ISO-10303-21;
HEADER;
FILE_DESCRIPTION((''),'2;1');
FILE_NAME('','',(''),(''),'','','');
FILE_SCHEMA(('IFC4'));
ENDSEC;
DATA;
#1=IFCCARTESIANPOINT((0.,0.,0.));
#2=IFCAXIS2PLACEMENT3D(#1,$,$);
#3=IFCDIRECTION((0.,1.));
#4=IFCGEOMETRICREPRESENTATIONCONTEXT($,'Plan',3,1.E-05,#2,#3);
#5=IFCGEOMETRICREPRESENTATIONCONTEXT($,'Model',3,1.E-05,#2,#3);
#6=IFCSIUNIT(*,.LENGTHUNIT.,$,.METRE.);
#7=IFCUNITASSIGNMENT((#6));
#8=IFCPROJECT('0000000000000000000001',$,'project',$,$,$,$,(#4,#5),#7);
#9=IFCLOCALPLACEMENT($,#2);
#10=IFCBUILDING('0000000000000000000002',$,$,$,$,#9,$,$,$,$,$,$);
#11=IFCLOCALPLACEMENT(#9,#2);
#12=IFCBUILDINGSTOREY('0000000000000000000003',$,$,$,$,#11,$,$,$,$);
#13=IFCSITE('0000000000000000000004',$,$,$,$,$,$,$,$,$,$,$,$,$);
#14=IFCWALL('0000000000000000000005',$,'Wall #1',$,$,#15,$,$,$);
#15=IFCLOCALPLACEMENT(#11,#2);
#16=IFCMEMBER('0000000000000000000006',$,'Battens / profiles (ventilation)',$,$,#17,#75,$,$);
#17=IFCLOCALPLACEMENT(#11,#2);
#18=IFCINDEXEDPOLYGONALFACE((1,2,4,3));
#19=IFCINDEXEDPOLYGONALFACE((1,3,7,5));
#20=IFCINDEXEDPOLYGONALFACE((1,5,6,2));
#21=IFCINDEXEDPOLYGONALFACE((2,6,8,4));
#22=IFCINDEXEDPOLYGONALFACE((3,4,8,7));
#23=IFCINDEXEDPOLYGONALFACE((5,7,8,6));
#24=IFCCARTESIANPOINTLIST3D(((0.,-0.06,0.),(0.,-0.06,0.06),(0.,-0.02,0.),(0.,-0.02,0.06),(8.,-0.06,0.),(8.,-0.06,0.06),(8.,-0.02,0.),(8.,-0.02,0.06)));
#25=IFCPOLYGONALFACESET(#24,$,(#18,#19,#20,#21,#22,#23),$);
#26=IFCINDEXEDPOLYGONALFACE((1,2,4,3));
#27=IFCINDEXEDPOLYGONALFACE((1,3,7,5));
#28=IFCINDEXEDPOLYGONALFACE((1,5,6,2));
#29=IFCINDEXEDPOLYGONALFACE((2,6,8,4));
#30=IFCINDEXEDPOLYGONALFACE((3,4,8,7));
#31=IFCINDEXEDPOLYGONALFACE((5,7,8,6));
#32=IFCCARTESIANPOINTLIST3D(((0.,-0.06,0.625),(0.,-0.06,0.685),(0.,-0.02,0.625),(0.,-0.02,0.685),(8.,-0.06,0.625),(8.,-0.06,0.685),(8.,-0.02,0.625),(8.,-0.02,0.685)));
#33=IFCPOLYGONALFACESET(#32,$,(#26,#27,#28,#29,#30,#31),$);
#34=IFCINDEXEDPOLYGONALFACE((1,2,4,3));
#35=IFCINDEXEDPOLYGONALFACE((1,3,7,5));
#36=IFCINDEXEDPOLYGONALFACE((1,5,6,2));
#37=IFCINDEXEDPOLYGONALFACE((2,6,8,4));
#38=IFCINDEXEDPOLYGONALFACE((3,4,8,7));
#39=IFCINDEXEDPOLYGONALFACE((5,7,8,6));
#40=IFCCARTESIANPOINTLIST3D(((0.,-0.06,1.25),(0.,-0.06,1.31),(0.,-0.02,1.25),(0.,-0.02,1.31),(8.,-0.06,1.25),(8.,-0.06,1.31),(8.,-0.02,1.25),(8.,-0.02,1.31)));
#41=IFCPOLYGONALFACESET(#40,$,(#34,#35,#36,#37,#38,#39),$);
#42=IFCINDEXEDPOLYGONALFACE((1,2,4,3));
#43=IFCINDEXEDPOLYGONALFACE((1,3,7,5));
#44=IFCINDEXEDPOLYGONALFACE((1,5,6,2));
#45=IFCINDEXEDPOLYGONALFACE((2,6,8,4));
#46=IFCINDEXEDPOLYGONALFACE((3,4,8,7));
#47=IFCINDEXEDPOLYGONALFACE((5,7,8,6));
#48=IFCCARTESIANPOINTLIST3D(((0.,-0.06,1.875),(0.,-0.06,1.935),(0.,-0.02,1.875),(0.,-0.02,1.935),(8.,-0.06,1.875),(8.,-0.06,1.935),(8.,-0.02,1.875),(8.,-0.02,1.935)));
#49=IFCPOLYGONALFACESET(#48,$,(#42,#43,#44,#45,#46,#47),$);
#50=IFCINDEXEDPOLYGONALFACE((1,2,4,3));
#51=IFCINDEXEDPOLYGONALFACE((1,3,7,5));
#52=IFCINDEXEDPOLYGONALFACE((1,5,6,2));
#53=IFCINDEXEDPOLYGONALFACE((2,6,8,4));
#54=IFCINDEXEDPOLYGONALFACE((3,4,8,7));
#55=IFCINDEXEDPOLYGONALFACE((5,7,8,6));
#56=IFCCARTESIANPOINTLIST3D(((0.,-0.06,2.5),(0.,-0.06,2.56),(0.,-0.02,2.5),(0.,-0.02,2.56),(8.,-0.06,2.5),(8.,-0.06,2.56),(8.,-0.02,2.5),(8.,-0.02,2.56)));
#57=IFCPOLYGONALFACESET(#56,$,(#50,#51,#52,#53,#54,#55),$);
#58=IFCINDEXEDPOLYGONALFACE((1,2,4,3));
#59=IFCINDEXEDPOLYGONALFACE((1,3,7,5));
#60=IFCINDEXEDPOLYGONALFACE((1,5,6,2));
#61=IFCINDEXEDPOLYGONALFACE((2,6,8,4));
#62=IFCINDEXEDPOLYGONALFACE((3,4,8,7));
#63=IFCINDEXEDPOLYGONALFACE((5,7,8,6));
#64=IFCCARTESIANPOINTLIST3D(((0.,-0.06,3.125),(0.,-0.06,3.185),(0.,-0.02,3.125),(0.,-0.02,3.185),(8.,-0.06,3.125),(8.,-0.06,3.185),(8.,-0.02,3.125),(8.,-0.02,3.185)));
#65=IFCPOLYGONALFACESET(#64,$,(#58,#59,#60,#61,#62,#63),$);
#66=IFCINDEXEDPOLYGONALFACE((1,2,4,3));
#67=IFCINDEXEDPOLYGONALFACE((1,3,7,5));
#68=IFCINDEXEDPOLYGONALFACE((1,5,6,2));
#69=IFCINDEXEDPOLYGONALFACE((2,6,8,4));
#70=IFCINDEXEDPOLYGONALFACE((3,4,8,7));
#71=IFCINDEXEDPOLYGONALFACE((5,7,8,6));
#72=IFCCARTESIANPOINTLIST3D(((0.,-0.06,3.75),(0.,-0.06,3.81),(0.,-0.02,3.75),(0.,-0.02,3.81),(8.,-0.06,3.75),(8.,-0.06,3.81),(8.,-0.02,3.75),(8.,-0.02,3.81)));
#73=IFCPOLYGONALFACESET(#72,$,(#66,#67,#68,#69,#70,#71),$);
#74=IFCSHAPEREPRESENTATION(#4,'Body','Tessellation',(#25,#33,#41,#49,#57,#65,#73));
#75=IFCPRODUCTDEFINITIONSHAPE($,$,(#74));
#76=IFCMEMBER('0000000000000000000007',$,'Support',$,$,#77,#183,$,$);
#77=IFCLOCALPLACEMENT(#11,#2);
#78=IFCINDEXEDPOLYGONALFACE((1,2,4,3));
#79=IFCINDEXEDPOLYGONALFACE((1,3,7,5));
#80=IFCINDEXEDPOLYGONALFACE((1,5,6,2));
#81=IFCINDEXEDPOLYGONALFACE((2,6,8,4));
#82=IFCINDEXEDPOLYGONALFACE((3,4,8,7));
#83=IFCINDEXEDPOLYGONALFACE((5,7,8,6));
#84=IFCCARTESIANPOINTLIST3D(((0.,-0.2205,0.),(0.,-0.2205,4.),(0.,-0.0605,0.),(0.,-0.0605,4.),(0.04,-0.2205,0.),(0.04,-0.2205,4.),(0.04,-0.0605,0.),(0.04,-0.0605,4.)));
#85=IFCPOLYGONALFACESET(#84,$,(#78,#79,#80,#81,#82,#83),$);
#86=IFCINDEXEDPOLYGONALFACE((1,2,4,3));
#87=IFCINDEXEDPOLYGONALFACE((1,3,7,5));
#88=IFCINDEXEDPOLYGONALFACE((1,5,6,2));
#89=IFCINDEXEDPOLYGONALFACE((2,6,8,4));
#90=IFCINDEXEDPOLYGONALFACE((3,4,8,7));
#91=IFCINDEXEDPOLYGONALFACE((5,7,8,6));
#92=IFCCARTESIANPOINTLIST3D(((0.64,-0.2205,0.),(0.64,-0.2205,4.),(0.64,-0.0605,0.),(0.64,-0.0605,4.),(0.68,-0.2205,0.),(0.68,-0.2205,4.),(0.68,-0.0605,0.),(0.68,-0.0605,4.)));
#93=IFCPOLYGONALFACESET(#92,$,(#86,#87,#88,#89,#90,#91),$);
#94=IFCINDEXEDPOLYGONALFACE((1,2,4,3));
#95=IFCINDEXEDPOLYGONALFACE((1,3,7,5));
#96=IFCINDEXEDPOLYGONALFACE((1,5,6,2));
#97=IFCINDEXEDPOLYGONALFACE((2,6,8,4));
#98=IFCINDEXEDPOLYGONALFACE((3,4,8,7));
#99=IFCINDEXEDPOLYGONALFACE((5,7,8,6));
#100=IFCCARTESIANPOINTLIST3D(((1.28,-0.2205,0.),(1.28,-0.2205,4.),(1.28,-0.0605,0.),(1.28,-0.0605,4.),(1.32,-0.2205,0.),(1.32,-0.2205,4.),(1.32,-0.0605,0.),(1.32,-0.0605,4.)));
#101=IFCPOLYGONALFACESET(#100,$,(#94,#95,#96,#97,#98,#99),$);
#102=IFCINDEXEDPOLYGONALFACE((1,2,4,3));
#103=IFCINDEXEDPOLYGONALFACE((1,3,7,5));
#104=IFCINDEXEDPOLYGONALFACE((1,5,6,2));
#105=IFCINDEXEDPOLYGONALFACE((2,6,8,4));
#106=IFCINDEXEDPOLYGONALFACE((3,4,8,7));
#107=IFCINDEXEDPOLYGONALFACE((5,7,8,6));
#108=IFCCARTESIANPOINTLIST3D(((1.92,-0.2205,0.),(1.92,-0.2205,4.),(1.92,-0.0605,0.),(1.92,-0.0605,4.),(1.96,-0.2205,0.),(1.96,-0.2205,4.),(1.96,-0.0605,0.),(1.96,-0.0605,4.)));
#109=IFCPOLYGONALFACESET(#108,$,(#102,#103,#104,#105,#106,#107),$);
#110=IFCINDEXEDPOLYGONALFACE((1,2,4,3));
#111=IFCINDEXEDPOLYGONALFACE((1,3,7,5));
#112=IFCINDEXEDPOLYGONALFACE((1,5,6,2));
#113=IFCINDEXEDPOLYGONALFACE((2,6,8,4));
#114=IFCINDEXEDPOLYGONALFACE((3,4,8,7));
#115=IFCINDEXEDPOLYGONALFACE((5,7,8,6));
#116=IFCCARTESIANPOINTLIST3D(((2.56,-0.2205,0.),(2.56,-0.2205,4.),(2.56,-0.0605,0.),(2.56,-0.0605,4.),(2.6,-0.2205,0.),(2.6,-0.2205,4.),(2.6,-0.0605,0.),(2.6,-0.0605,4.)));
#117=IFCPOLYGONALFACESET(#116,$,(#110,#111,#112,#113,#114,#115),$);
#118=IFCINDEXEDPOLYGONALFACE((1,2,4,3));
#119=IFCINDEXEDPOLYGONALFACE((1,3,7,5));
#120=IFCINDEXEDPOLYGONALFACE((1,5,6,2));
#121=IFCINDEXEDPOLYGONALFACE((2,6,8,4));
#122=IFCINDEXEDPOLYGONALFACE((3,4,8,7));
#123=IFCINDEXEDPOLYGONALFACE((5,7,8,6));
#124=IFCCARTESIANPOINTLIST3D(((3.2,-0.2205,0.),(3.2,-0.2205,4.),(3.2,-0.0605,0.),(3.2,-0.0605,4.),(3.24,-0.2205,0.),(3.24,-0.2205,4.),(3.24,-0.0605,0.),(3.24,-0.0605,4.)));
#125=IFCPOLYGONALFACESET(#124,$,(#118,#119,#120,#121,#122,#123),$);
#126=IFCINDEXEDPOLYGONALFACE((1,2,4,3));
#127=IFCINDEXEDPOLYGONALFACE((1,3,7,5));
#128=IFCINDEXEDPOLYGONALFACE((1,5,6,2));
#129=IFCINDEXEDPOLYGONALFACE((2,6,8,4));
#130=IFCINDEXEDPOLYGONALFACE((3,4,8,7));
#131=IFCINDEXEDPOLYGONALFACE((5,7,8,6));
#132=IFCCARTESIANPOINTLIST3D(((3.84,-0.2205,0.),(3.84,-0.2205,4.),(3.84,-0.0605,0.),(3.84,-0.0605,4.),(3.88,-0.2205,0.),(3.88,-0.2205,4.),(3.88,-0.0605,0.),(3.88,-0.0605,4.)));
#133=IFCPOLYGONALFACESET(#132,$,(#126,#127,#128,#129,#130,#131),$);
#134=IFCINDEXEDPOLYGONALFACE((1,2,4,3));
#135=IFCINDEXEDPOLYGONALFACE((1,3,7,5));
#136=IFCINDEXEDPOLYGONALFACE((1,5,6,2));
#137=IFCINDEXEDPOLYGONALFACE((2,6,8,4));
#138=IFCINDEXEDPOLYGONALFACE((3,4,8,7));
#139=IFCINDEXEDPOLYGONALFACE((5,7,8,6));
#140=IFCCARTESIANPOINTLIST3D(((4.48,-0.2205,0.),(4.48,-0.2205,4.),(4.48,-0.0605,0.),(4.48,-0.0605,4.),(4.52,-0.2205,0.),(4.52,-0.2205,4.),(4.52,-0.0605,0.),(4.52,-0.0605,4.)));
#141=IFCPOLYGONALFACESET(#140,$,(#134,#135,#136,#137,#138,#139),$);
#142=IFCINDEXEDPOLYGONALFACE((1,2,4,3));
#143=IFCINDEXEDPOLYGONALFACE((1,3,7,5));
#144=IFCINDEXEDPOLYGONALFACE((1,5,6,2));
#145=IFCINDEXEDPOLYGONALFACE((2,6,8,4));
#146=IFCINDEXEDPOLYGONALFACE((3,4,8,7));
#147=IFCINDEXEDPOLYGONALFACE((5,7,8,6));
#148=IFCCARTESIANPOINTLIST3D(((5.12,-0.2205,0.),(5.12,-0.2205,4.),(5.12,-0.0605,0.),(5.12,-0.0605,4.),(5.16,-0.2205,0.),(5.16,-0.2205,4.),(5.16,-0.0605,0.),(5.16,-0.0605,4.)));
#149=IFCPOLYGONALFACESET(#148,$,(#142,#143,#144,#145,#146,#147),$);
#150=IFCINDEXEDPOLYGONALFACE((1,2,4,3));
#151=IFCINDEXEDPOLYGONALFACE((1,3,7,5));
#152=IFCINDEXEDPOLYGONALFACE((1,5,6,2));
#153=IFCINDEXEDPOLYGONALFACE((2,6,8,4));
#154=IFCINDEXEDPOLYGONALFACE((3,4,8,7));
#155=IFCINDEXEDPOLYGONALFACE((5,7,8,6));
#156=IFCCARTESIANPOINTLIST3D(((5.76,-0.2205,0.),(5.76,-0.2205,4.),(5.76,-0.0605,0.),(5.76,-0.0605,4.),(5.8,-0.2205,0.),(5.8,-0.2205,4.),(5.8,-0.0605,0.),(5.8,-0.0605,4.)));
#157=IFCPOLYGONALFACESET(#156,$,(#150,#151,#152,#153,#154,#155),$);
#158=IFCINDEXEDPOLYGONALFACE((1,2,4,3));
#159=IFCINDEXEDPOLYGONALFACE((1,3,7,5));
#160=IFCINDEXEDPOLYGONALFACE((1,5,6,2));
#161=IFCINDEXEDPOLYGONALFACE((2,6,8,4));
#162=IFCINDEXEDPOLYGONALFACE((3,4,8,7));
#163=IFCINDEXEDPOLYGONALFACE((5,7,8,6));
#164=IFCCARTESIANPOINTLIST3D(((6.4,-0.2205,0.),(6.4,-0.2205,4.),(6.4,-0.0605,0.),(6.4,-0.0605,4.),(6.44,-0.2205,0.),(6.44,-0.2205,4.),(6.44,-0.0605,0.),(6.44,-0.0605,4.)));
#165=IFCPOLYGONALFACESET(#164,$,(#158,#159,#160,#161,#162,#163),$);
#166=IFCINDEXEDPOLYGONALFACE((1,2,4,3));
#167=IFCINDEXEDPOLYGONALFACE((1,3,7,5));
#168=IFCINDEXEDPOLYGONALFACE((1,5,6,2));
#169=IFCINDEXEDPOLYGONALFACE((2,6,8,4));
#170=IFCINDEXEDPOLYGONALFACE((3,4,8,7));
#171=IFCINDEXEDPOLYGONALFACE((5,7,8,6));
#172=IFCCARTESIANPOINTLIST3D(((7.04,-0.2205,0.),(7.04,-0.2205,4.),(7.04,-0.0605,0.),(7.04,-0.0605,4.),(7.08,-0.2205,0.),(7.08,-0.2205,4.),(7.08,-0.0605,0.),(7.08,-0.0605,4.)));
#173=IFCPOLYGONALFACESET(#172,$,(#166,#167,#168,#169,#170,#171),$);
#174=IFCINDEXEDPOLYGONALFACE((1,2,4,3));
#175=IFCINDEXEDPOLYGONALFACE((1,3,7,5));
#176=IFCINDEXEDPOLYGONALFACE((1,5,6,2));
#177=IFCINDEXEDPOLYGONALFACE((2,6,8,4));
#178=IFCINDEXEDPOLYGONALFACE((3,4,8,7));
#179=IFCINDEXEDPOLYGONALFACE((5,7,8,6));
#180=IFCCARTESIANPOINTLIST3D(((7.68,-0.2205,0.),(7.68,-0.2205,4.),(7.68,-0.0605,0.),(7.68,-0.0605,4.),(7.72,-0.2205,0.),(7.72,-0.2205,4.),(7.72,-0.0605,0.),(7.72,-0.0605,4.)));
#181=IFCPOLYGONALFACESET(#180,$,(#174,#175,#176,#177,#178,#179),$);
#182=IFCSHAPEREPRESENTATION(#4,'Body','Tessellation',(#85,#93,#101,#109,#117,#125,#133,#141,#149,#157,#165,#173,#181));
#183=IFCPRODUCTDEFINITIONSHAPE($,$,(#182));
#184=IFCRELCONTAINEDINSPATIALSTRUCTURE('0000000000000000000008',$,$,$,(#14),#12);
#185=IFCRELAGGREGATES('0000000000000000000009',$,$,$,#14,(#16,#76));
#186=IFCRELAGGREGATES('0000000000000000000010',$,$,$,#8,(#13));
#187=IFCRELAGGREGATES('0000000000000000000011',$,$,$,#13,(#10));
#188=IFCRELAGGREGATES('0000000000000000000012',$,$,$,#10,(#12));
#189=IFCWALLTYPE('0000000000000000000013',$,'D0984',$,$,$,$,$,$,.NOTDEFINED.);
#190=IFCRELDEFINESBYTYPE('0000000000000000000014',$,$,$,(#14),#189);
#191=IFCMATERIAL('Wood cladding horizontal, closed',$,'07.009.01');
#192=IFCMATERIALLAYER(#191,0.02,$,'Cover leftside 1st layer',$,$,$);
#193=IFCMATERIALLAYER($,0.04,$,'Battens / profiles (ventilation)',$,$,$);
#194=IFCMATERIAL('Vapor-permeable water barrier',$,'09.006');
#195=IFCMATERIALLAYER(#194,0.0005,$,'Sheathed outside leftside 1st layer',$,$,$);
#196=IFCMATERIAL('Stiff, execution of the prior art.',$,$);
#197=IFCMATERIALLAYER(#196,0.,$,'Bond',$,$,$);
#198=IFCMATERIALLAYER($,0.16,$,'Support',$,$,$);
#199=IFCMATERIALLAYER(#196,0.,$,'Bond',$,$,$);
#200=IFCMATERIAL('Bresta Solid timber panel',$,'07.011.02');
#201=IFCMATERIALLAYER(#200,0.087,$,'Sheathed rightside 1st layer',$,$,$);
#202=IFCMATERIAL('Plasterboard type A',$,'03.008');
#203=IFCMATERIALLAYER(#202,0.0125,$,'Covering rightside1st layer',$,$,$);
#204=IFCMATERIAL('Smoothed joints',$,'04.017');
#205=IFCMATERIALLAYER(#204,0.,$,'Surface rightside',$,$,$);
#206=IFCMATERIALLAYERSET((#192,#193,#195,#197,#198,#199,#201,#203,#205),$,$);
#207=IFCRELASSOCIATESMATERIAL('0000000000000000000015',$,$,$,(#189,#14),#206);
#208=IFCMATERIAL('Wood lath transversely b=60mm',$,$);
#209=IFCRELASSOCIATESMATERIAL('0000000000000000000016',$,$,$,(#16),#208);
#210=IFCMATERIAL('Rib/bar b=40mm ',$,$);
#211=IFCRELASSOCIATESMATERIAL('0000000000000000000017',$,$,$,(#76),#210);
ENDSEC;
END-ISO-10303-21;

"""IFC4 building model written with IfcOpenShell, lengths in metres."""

from ifc_helpers import new_model, si_unit, direction, frame, frame_2d, origin, place, context, project, spatial, rectangle, extrude, material, layer, layer_set, type_object, element, aggregate, save


model = new_model("IFC4")

# Units and contexts
plan_context = context("Plan", 3, precision=1e-05, world=origin(), true_north=direction((0.0, 1.0)))
model_context = context("Model", 3, precision=1e-05, world=origin(), true_north=direction((0.0, 1.0)))
ifc_project = project(units=[si_unit("LENGTHUNIT", "METRE")], contexts=[plan_context, model_context])

# Site, building, storey
site = spatial("IfcSite", under=ifc_project)
building_placement = place(None, origin())
building = spatial("IfcBuilding", under=site, at=building_placement)
storey_placement = place(building_placement, origin())
storey = spatial("IfcBuildingStorey", under=building, at=storey_placement)

# Wall, members
ifc_material_1 = material(Name="Wood cladding horizontal, closed", Category="07.009.01")
ifc_layer_1 = layer(ifc_material_1, 0.02, Name="Cover leftside 1st layer")
ifc_layer_2 = layer(None, 0.04, Name="Battens / profiles (ventilation)")
ifc_material_2 = material(Name="Vapor-permeable water barrier", Category="09.006")
ifc_layer_3 = layer(ifc_material_2, 0.0005, Name="Sheathed outside leftside 1st layer")
ifc_material_3 = material(Name="Stiff, execution of the prior art.")
ifc_layer_4 = layer(ifc_material_3, 0.0, Name="Bond")
ifc_layer_5 = layer(None, 0.16, Name="Support")
ifc_layer_6 = layer(ifc_material_3, 0.0, Name="Bond")
ifc_material_4 = material(Name="Bresta Solid timber panel", Category="07.011.02")
ifc_layer_7 = layer(ifc_material_4, 0.087, Name="Sheathed rightside 1st layer")
ifc_material_5 = material(Name="Plasterboard type A", Category="03.008")
ifc_layer_8 = layer(ifc_material_5, 0.0125, Name="Covering rightside1st layer")
ifc_material_6 = material(Name="Smoothed joints", Category="04.017")
ifc_layer_9 = layer(ifc_material_6, 0.0, Name="Surface rightside")
ifc_layer_set = layer_set([ifc_layer_1, ifc_layer_2, ifc_layer_3, ifc_layer_4, ifc_layer_5, ifc_layer_6, ifc_layer_7, ifc_layer_8, ifc_layer_9])
wall_type = type_object("IfcWallType", Name="D0984", PredefinedType="NOTDEFINED", material=ifc_layer_set)
wall_placement = place(None, frame((0.0, 0.0, 0.0), z_axis=(0.0, -1.0, 0.0), x_axis=(1.0, 0.0, 0.0)))
wall = element("IfcWall", 1, at=wall_placement, inside=storey, type_object=wall_type, material=ifc_layer_set, Name="Wall #1")
ifc_material_7 = material(Name="Wood lath transversely b=60mm")
member_1_placement = place(wall_placement, origin())
member_1 = element("IfcMember", 2, at=member_1_placement, material=ifc_material_7, Name="Battens / profiles (ventilation)", context=plan_context, shape_type="SweptSolid", body=[
    extrude(rectangle(XDim=0.06, YDim=0.04, at=frame_2d((0.03, 0.02), x_axis=(1.0, 0.0))), frame((0.0, 0.0, 0.02), z_axis=(1.0, 0.0, 0.0), x_axis=(0.0, 1.0, 0.0)), (0.0, 0.0, 1.0), 8.0),
    extrude(rectangle(XDim=0.06, YDim=0.04, at=frame_2d((0.03, 0.02), x_axis=(1.0, 0.0))), frame((0.0, 0.625, 0.02), z_axis=(1.0, 0.0, 0.0), x_axis=(0.0, 1.0, 0.0)), (0.0, 0.0, 1.0), 8.0),
    extrude(rectangle(XDim=0.06, YDim=0.04, at=frame_2d((0.03, 0.02), x_axis=(1.0, 0.0))), frame((0.0, 1.25, 0.02), z_axis=(1.0, 0.0, 0.0), x_axis=(0.0, 1.0, 0.0)), (0.0, 0.0, 1.0), 8.0),
    extrude(rectangle(XDim=0.06, YDim=0.04, at=frame_2d((0.03, 0.02), x_axis=(1.0, 0.0))), frame((0.0, 1.875, 0.02), z_axis=(1.0, 0.0, 0.0), x_axis=(0.0, 1.0, 0.0)), (0.0, 0.0, 1.0), 8.0),
    extrude(rectangle(XDim=0.06, YDim=0.04, at=frame_2d((0.03, 0.02), x_axis=(1.0, 0.0))), frame((0.0, 2.5, 0.02), z_axis=(1.0, 0.0, 0.0), x_axis=(0.0, 1.0, 0.0)), (0.0, 0.0, 1.0), 8.0),
    extrude(rectangle(XDim=0.06, YDim=0.04, at=frame_2d((0.03, 0.02), x_axis=(1.0, 0.0))), frame((0.0, 3.125, 0.02), z_axis=(1.0, 0.0, 0.0), x_axis=(0.0, 1.0, 0.0)), (0.0, 0.0, 1.0), 8.0),
    extrude(rectangle(XDim=0.06, YDim=0.04, at=frame_2d((0.03, 0.02), x_axis=(1.0, 0.0))), frame((0.0, 3.75, 0.02), z_axis=(1.0, 0.0, 0.0), x_axis=(0.0, 1.0, 0.0)), (0.0, 0.0, 1.0), 8.0),
])
ifc_material_8 = material(Name="Rib/bar b=40mm ")
member_2_placement = place(wall_placement, origin())
member_2 = element("IfcMember", 3, at=member_2_placement, material=ifc_material_8, Name="Support", context=plan_context, shape_type="SweptSolid", body=[
    extrude(rectangle(XDim=0.04, YDim=0.16, at=frame_2d((0.02, 0.08), x_axis=(1.0, 0.0))), frame((0.0, 4.0, 0.0605), z_axis=(0.0, -1.0, 0.0), x_axis=(1.0, 0.0, 0.0)), (0.0, 0.0, 1.0), 4.0),
    extrude(rectangle(XDim=0.04, YDim=0.16, at=frame_2d((0.02, 0.08), x_axis=(1.0, 0.0))), frame((0.64, 4.0, 0.0605), z_axis=(0.0, -1.0, 0.0), x_axis=(1.0, 0.0, 0.0)), (0.0, 0.0, 1.0), 4.0),
    extrude(rectangle(XDim=0.04, YDim=0.16, at=frame_2d((0.02, 0.08), x_axis=(1.0, 0.0))), frame((1.28, 4.0, 0.0605), z_axis=(0.0, -1.0, 0.0), x_axis=(1.0, 0.0, 0.0)), (0.0, 0.0, 1.0), 4.0),
    extrude(rectangle(XDim=0.04, YDim=0.16, at=frame_2d((0.02, 0.08), x_axis=(1.0, 0.0))), frame((1.92, 4.0, 0.0605), z_axis=(0.0, -1.0, 0.0), x_axis=(1.0, 0.0, 0.0)), (0.0, 0.0, 1.0), 4.0),
    extrude(rectangle(XDim=0.04, YDim=0.16, at=frame_2d((0.02, 0.08), x_axis=(1.0, 0.0))), frame((2.56, 4.0, 0.0605), z_axis=(0.0, -1.0, 0.0), x_axis=(1.0, 0.0, 0.0)), (0.0, 0.0, 1.0), 4.0),
    extrude(rectangle(XDim=0.04, YDim=0.16, at=frame_2d((0.02, 0.08), x_axis=(1.0, 0.0))), frame((3.2, 4.0, 0.0605), z_axis=(0.0, -1.0, 0.0), x_axis=(1.0, 0.0, 0.0)), (0.0, 0.0, 1.0), 4.0),
    extrude(rectangle(XDim=0.04, YDim=0.16, at=frame_2d((0.02, 0.08), x_axis=(1.0, 0.0))), frame((3.84, 4.0, 0.0605), z_axis=(0.0, -1.0, 0.0), x_axis=(1.0, 0.0, 0.0)), (0.0, 0.0, 1.0), 4.0),
    extrude(rectangle(XDim=0.04, YDim=0.16, at=frame_2d((0.02, 0.08), x_axis=(1.0, 0.0))), frame((4.48, 4.0, 0.0605), z_axis=(0.0, -1.0, 0.0), x_axis=(1.0, 0.0, 0.0)), (0.0, 0.0, 1.0), 4.0),
    extrude(rectangle(XDim=0.04, YDim=0.16, at=frame_2d((0.02, 0.08), x_axis=(1.0, 0.0))), frame((5.12, 4.0, 0.0605), z_axis=(0.0, -1.0, 0.0), x_axis=(1.0, 0.0, 0.0)), (0.0, 0.0, 1.0), 4.0),
    extrude(rectangle(XDim=0.04, YDim=0.16, at=frame_2d((0.02, 0.08), x_axis=(1.0, 0.0))), frame((5.76, 4.0, 0.0605), z_axis=(0.0, -1.0, 0.0), x_axis=(1.0, 0.0, 0.0)), (0.0, 0.0, 1.0), 4.0),
    extrude(rectangle(XDim=0.04, YDim=0.16, at=frame_2d((0.02, 0.08), x_axis=(1.0, 0.0))), frame((6.4, 4.0, 0.0605), z_axis=(0.0, -1.0, 0.0), x_axis=(1.0, 0.0, 0.0)), (0.0, 0.0, 1.0), 4.0),
    extrude(rectangle(XDim=0.04, YDim=0.16, at=frame_2d((0.02, 0.08), x_axis=(1.0, 0.0))), frame((7.04, 4.0, 0.0605), z_axis=(0.0, -1.0, 0.0), x_axis=(1.0, 0.0, 0.0)), (0.0, 0.0, 1.0), 4.0),
    extrude(rectangle(XDim=0.04, YDim=0.16, at=frame_2d((0.02, 0.08), x_axis=(1.0, 0.0))), frame((7.68, 4.0, 0.0605), z_axis=(0.0, -1.0, 0.0), x_axis=(1.0, 0.0, 0.0)), (0.0, 0.0, 1.0), 4.0),
])
aggregate(wall, [member_1, member_2])

save(model, "model.ifc")
